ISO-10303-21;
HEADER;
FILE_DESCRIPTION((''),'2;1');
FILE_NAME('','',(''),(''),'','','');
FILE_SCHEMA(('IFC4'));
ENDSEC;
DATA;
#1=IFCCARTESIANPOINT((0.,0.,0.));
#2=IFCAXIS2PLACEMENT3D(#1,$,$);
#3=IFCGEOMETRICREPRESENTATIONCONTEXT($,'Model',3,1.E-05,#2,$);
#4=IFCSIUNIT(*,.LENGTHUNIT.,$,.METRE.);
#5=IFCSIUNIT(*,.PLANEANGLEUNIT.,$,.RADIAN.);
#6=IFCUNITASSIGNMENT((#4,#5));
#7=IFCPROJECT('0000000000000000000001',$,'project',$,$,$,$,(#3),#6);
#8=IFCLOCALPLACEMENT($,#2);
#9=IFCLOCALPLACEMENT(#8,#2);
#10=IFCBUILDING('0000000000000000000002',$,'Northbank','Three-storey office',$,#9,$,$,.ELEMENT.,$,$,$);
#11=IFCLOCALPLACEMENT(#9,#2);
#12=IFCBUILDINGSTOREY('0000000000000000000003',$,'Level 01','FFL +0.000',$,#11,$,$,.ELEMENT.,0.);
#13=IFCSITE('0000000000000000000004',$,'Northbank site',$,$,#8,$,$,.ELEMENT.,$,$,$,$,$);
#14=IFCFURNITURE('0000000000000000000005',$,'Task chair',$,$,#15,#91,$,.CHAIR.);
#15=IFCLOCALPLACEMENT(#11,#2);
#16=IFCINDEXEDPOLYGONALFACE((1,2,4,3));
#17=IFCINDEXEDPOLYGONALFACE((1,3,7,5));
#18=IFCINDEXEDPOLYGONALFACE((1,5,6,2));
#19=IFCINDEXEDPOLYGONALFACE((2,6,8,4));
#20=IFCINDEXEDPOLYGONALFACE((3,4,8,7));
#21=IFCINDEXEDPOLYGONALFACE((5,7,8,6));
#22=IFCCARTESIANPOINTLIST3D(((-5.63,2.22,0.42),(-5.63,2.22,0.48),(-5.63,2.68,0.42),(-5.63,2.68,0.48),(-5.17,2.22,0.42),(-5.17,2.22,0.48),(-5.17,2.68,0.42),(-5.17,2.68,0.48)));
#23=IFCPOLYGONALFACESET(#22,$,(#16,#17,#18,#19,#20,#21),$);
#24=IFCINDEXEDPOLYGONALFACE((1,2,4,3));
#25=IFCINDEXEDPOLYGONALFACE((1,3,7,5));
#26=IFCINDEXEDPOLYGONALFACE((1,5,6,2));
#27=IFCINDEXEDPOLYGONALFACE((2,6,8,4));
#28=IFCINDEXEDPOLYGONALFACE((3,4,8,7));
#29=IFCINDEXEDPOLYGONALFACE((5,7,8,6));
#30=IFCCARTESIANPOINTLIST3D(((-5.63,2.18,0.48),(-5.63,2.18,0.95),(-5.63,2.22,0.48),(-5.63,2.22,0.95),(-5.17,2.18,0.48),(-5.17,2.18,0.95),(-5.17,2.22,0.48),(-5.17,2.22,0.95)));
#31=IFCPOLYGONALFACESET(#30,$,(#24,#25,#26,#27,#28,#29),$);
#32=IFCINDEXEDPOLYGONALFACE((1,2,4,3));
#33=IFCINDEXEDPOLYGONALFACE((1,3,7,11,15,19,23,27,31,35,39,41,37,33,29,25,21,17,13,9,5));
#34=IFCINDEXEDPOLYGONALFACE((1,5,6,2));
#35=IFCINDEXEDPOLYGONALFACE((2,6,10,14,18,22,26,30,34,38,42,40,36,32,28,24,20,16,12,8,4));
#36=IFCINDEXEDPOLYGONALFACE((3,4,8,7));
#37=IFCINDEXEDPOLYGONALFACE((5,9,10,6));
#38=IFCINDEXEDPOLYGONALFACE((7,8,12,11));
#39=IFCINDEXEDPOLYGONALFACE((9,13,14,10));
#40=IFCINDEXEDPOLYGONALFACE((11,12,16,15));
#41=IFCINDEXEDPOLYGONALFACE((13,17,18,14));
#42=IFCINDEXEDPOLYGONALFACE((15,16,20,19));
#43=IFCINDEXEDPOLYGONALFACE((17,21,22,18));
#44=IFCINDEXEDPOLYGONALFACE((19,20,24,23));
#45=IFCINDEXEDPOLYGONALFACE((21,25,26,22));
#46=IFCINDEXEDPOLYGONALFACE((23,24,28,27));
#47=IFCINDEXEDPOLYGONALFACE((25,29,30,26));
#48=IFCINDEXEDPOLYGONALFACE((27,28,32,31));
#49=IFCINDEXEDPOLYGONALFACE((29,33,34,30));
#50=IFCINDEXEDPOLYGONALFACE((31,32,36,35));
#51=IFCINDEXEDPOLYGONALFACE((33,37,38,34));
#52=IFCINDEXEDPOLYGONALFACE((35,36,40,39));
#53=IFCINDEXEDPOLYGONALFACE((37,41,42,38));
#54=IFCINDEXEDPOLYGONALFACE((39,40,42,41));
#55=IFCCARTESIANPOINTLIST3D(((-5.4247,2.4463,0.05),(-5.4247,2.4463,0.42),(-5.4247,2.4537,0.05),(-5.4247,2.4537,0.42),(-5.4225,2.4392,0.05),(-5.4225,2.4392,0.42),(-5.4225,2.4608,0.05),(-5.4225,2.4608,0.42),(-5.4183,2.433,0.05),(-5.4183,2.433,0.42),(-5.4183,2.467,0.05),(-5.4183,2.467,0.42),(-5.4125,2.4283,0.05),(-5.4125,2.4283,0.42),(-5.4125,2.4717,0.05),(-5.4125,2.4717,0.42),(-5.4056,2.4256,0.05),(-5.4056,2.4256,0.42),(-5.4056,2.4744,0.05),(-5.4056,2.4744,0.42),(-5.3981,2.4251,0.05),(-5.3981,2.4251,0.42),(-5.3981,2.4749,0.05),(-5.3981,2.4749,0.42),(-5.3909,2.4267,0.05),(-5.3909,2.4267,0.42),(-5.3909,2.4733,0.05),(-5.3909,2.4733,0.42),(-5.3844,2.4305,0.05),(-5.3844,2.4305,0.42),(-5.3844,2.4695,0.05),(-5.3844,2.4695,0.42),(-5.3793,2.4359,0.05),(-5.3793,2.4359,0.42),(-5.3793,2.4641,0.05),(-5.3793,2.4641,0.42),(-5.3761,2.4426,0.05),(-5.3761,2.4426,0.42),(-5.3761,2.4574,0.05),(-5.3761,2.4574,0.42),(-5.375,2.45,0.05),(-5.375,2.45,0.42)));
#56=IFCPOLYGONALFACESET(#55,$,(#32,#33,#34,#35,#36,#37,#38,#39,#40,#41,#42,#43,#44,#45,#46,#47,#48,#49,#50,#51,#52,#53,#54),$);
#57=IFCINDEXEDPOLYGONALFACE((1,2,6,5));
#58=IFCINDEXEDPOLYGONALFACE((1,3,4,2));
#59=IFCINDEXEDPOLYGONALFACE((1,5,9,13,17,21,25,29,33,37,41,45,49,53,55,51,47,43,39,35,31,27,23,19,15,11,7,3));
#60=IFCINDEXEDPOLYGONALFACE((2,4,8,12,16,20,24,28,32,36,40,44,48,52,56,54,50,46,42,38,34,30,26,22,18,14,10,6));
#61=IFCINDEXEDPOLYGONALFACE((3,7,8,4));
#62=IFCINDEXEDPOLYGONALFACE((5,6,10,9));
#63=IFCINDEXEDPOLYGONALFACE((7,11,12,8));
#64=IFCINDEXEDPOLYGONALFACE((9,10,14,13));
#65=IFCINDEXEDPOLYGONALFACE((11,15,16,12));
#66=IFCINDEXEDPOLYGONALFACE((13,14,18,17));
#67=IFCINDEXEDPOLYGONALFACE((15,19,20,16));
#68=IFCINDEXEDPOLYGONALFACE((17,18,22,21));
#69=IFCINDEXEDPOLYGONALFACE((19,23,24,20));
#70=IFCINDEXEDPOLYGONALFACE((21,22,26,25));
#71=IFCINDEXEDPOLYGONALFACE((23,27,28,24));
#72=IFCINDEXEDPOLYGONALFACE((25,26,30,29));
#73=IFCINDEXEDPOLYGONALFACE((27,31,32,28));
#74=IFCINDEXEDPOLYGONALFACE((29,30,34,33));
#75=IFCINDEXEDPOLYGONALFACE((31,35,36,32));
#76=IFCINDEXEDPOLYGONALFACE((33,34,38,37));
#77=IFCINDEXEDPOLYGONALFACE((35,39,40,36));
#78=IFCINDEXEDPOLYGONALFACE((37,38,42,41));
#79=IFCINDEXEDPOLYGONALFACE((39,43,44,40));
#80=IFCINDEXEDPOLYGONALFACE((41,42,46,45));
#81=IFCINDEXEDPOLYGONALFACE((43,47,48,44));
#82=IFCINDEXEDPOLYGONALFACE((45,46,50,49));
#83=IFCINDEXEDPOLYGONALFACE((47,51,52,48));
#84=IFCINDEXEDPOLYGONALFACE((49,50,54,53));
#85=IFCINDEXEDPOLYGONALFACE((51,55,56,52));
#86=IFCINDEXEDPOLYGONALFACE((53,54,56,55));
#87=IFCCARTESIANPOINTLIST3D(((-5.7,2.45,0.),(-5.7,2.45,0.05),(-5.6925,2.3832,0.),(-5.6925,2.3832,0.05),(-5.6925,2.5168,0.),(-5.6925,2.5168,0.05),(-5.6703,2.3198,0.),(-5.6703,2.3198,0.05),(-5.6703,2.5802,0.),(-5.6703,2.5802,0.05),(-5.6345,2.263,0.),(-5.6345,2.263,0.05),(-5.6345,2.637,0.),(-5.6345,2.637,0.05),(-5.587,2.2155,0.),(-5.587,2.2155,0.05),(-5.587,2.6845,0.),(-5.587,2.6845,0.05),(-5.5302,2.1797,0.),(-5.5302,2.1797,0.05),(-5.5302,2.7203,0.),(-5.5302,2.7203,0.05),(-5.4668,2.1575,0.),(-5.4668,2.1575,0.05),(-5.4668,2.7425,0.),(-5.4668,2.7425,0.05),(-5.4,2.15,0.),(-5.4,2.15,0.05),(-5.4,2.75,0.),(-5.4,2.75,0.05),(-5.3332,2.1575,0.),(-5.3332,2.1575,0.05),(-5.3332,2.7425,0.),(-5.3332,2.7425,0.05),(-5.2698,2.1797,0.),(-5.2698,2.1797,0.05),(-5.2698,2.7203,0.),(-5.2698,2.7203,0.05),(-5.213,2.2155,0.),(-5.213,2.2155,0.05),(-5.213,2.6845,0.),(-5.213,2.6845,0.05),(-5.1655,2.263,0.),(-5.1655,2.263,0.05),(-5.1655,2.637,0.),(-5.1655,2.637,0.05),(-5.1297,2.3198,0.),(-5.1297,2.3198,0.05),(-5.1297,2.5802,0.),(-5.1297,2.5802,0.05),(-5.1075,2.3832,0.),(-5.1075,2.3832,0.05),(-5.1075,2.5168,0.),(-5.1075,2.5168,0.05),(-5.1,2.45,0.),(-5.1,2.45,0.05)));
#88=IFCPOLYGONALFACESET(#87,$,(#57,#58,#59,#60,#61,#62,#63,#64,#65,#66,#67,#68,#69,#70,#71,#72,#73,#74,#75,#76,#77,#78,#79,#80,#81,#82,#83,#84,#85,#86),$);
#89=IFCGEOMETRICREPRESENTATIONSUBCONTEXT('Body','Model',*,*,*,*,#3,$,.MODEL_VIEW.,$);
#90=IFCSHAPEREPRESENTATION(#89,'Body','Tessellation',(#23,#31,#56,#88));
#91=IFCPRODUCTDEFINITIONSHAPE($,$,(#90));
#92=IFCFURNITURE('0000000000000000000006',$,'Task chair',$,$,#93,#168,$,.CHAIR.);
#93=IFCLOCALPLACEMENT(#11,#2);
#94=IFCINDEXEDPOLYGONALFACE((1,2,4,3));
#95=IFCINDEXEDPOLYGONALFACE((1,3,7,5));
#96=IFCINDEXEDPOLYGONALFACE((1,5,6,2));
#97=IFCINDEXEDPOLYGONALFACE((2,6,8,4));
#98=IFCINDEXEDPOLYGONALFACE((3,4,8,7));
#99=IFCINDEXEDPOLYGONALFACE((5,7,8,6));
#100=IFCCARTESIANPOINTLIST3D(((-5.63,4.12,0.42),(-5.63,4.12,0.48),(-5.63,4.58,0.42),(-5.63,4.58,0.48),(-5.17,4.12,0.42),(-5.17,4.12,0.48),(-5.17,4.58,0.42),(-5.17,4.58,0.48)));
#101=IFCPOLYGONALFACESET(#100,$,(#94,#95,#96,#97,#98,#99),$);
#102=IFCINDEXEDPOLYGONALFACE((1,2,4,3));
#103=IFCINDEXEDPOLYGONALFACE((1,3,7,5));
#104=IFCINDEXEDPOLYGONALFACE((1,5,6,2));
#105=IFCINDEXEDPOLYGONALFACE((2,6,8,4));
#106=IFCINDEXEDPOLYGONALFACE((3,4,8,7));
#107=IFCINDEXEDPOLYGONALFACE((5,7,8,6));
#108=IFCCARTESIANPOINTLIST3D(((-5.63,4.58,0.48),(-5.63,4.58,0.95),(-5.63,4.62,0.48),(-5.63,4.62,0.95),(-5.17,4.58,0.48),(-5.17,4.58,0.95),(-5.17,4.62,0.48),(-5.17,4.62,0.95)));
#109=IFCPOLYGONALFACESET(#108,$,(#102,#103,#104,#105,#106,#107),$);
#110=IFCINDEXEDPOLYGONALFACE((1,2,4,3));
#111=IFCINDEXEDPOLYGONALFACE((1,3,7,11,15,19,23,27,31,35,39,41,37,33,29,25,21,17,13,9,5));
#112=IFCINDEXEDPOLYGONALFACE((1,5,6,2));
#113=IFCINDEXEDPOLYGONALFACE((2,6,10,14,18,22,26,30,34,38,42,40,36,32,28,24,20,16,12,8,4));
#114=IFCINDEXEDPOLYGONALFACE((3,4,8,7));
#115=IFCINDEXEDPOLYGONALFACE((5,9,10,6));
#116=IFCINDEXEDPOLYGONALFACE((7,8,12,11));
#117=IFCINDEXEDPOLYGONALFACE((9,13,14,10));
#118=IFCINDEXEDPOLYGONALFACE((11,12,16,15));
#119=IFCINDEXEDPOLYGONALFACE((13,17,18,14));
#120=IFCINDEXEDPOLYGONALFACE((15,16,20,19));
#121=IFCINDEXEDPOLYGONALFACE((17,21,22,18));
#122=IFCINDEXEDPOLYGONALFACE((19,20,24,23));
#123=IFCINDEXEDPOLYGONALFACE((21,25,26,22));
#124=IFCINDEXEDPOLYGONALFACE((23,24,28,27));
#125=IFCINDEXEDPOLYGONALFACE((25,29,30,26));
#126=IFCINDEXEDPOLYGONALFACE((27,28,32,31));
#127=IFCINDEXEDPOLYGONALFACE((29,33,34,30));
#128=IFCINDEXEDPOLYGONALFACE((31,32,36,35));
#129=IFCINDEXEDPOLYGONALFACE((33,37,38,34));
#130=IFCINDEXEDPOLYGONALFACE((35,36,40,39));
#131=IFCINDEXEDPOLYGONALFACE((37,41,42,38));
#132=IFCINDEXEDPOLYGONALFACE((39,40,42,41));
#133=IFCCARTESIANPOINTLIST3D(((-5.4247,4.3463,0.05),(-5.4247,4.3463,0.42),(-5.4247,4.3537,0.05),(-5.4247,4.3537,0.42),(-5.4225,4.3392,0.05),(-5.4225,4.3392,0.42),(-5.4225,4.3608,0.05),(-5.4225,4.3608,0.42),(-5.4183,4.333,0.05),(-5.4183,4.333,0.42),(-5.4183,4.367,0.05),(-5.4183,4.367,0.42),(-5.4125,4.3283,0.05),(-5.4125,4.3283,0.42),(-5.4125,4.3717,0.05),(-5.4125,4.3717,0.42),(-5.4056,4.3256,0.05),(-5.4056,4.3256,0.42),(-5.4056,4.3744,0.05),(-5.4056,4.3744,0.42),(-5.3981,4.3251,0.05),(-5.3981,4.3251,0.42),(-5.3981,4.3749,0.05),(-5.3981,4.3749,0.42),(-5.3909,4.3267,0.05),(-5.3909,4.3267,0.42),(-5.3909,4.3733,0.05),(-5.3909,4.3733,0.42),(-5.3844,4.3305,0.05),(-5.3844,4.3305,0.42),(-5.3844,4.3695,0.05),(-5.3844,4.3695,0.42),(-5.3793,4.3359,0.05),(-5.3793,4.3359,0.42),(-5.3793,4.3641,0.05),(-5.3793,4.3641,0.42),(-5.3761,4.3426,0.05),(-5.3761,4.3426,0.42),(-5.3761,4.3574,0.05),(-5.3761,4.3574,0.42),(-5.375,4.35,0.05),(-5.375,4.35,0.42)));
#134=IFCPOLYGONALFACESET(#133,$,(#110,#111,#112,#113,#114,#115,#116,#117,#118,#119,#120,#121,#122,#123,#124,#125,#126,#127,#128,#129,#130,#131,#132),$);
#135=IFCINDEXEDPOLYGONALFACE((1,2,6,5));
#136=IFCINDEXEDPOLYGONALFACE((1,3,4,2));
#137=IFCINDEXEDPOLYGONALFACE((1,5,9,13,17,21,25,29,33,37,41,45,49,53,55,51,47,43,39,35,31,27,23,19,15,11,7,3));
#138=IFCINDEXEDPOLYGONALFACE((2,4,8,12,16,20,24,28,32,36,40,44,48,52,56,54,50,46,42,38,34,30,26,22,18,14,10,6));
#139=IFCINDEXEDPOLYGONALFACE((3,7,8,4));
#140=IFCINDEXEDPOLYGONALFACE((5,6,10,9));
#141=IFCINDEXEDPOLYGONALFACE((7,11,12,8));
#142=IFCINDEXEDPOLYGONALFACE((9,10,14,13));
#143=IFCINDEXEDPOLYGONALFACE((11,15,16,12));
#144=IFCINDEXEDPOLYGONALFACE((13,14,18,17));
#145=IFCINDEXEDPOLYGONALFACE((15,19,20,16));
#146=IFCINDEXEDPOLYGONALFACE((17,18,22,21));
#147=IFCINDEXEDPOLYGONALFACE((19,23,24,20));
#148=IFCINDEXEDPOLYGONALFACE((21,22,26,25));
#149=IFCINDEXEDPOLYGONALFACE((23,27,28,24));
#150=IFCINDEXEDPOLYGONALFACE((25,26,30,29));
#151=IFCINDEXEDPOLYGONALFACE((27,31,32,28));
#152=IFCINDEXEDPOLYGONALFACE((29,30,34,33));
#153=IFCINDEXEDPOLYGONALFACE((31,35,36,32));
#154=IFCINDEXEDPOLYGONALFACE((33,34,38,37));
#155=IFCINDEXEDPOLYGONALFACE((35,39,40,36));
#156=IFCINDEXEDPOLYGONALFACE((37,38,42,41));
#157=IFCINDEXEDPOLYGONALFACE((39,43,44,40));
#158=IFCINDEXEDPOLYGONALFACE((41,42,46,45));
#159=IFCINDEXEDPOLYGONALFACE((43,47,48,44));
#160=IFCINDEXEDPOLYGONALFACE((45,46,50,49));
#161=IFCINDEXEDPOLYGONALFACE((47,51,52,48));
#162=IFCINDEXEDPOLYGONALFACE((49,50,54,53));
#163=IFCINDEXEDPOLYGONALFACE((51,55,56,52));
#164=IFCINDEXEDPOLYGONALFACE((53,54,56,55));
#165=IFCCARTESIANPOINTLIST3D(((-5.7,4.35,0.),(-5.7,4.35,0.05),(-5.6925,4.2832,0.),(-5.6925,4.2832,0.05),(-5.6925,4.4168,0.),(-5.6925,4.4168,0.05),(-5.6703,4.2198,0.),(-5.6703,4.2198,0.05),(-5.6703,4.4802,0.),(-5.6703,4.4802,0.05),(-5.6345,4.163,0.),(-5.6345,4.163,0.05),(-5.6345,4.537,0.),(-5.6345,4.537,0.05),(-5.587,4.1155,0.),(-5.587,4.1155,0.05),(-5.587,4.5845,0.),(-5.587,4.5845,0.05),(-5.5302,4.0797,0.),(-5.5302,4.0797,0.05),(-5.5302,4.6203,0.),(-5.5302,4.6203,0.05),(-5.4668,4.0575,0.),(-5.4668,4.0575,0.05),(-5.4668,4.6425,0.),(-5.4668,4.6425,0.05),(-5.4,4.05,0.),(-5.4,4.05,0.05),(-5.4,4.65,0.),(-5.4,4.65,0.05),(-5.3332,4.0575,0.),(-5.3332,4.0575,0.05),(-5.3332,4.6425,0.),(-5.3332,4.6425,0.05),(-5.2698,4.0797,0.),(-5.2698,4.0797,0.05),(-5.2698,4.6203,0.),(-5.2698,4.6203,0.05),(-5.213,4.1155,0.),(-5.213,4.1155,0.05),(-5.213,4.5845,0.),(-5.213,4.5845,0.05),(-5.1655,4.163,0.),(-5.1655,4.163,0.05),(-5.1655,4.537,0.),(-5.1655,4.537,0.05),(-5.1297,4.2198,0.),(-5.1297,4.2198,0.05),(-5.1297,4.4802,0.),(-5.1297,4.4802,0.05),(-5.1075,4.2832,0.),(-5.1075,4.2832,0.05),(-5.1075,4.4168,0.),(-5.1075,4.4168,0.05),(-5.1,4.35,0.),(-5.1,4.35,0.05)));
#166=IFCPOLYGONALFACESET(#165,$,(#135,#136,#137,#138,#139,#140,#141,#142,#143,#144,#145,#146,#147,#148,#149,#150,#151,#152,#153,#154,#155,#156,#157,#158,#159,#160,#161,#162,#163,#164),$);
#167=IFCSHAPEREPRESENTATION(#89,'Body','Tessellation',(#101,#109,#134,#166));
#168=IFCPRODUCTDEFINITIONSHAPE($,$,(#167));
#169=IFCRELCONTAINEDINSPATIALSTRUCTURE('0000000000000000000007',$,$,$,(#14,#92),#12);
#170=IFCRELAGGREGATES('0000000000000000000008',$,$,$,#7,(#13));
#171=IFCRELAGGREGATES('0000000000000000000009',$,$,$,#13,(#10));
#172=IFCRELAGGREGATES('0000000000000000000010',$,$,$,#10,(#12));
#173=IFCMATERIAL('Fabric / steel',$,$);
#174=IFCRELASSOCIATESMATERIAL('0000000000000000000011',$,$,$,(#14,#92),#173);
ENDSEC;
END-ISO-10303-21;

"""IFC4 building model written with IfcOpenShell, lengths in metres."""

from ifc_helpers import new_model, si_unit, frame, origin, place, context, subcontext, project, spatial, rectangle, circle, extrude, material, element, save


model = new_model("IFC4")

# Units and contexts
model_context = context("Model", 3, precision=1e-05, world=origin())
body_context = subcontext(model_context, "Body", "Model", "MODEL_VIEW")
ifc_project = project(units=[si_unit("LENGTHUNIT", "METRE"), si_unit("PLANEANGLEUNIT", "RADIAN")], contexts=[model_context])

# Site, building, storey
site_placement = place(None, origin())
site = spatial("IfcSite", under=ifc_project, at=site_placement, Name="Northbank site", CompositionType="ELEMENT")
building_placement = place(site_placement, origin())
building = spatial("IfcBuilding", under=site, at=building_placement, Name="Northbank", Description="Three-storey office", CompositionType="ELEMENT")
storey_placement = place(building_placement, origin())
storey = spatial("IfcBuildingStorey", under=building, at=storey_placement, Name="Level 01", Description="FFL +0.000", CompositionType="ELEMENT", Elevation=0.0)

# Furniture
ifc_material_1 = material(Name="Fabric / steel")
furniture_1_placement = place(storey_placement, origin())
element("IfcFurniture", 1, at=furniture_1_placement, inside=storey, material=ifc_material_1, Name="Task chair", PredefinedType="CHAIR", context=body_context, shape_type="SweptSolid", body=[
    extrude(rectangle(XDim=0.46, YDim=0.46), frame((-5.4, 2.45, 0.42)), (0.0, 0.0, 1.0), 0.06),
    extrude(rectangle(XDim=0.46, YDim=0.04), frame((-5.4, 2.2, 0.48)), (0.0, 0.0, 1.0), 0.47),
    extrude(circle(Radius=0.025), frame((-5.4, 2.45, 0.05), z_axis=(0.0, 0.0, 1.0), x_axis=(1.0, 0.0, 0.0)), (0.0, 0.0, 1.0), 0.37),
    extrude(circle(Radius=0.3), frame((-5.4, 2.45, 0.0), z_axis=(0.0, 0.0, 1.0), x_axis=(1.0, 0.0, 0.0)), (0.0, 0.0, 1.0), 0.05),
])
furniture_2_placement = place(storey_placement, origin())
element("IfcFurniture", 2, at=furniture_2_placement, inside=storey, material=ifc_material_1, Name="Task chair", PredefinedType="CHAIR", context=body_context, shape_type="SweptSolid", body=[
    extrude(rectangle(XDim=0.46, YDim=0.46), frame((-5.4, 4.35, 0.42)), (0.0, 0.0, 1.0), 0.06),
    extrude(rectangle(XDim=0.46, YDim=0.04), frame((-5.4, 4.6, 0.48)), (0.0, 0.0, 1.0), 0.47),
    extrude(circle(Radius=0.025), frame((-5.4, 4.35, 0.05), z_axis=(0.0, 0.0, 1.0), x_axis=(1.0, 0.0, 0.0)), (0.0, 0.0, 1.0), 0.37),
    extrude(circle(Radius=0.3), frame((-5.4, 4.35, 0.0), z_axis=(0.0, 0.0, 1.0), x_axis=(1.0, 0.0, 0.0)), (0.0, 0.0, 1.0), 0.05),
])

save(model, "model.ifc")
